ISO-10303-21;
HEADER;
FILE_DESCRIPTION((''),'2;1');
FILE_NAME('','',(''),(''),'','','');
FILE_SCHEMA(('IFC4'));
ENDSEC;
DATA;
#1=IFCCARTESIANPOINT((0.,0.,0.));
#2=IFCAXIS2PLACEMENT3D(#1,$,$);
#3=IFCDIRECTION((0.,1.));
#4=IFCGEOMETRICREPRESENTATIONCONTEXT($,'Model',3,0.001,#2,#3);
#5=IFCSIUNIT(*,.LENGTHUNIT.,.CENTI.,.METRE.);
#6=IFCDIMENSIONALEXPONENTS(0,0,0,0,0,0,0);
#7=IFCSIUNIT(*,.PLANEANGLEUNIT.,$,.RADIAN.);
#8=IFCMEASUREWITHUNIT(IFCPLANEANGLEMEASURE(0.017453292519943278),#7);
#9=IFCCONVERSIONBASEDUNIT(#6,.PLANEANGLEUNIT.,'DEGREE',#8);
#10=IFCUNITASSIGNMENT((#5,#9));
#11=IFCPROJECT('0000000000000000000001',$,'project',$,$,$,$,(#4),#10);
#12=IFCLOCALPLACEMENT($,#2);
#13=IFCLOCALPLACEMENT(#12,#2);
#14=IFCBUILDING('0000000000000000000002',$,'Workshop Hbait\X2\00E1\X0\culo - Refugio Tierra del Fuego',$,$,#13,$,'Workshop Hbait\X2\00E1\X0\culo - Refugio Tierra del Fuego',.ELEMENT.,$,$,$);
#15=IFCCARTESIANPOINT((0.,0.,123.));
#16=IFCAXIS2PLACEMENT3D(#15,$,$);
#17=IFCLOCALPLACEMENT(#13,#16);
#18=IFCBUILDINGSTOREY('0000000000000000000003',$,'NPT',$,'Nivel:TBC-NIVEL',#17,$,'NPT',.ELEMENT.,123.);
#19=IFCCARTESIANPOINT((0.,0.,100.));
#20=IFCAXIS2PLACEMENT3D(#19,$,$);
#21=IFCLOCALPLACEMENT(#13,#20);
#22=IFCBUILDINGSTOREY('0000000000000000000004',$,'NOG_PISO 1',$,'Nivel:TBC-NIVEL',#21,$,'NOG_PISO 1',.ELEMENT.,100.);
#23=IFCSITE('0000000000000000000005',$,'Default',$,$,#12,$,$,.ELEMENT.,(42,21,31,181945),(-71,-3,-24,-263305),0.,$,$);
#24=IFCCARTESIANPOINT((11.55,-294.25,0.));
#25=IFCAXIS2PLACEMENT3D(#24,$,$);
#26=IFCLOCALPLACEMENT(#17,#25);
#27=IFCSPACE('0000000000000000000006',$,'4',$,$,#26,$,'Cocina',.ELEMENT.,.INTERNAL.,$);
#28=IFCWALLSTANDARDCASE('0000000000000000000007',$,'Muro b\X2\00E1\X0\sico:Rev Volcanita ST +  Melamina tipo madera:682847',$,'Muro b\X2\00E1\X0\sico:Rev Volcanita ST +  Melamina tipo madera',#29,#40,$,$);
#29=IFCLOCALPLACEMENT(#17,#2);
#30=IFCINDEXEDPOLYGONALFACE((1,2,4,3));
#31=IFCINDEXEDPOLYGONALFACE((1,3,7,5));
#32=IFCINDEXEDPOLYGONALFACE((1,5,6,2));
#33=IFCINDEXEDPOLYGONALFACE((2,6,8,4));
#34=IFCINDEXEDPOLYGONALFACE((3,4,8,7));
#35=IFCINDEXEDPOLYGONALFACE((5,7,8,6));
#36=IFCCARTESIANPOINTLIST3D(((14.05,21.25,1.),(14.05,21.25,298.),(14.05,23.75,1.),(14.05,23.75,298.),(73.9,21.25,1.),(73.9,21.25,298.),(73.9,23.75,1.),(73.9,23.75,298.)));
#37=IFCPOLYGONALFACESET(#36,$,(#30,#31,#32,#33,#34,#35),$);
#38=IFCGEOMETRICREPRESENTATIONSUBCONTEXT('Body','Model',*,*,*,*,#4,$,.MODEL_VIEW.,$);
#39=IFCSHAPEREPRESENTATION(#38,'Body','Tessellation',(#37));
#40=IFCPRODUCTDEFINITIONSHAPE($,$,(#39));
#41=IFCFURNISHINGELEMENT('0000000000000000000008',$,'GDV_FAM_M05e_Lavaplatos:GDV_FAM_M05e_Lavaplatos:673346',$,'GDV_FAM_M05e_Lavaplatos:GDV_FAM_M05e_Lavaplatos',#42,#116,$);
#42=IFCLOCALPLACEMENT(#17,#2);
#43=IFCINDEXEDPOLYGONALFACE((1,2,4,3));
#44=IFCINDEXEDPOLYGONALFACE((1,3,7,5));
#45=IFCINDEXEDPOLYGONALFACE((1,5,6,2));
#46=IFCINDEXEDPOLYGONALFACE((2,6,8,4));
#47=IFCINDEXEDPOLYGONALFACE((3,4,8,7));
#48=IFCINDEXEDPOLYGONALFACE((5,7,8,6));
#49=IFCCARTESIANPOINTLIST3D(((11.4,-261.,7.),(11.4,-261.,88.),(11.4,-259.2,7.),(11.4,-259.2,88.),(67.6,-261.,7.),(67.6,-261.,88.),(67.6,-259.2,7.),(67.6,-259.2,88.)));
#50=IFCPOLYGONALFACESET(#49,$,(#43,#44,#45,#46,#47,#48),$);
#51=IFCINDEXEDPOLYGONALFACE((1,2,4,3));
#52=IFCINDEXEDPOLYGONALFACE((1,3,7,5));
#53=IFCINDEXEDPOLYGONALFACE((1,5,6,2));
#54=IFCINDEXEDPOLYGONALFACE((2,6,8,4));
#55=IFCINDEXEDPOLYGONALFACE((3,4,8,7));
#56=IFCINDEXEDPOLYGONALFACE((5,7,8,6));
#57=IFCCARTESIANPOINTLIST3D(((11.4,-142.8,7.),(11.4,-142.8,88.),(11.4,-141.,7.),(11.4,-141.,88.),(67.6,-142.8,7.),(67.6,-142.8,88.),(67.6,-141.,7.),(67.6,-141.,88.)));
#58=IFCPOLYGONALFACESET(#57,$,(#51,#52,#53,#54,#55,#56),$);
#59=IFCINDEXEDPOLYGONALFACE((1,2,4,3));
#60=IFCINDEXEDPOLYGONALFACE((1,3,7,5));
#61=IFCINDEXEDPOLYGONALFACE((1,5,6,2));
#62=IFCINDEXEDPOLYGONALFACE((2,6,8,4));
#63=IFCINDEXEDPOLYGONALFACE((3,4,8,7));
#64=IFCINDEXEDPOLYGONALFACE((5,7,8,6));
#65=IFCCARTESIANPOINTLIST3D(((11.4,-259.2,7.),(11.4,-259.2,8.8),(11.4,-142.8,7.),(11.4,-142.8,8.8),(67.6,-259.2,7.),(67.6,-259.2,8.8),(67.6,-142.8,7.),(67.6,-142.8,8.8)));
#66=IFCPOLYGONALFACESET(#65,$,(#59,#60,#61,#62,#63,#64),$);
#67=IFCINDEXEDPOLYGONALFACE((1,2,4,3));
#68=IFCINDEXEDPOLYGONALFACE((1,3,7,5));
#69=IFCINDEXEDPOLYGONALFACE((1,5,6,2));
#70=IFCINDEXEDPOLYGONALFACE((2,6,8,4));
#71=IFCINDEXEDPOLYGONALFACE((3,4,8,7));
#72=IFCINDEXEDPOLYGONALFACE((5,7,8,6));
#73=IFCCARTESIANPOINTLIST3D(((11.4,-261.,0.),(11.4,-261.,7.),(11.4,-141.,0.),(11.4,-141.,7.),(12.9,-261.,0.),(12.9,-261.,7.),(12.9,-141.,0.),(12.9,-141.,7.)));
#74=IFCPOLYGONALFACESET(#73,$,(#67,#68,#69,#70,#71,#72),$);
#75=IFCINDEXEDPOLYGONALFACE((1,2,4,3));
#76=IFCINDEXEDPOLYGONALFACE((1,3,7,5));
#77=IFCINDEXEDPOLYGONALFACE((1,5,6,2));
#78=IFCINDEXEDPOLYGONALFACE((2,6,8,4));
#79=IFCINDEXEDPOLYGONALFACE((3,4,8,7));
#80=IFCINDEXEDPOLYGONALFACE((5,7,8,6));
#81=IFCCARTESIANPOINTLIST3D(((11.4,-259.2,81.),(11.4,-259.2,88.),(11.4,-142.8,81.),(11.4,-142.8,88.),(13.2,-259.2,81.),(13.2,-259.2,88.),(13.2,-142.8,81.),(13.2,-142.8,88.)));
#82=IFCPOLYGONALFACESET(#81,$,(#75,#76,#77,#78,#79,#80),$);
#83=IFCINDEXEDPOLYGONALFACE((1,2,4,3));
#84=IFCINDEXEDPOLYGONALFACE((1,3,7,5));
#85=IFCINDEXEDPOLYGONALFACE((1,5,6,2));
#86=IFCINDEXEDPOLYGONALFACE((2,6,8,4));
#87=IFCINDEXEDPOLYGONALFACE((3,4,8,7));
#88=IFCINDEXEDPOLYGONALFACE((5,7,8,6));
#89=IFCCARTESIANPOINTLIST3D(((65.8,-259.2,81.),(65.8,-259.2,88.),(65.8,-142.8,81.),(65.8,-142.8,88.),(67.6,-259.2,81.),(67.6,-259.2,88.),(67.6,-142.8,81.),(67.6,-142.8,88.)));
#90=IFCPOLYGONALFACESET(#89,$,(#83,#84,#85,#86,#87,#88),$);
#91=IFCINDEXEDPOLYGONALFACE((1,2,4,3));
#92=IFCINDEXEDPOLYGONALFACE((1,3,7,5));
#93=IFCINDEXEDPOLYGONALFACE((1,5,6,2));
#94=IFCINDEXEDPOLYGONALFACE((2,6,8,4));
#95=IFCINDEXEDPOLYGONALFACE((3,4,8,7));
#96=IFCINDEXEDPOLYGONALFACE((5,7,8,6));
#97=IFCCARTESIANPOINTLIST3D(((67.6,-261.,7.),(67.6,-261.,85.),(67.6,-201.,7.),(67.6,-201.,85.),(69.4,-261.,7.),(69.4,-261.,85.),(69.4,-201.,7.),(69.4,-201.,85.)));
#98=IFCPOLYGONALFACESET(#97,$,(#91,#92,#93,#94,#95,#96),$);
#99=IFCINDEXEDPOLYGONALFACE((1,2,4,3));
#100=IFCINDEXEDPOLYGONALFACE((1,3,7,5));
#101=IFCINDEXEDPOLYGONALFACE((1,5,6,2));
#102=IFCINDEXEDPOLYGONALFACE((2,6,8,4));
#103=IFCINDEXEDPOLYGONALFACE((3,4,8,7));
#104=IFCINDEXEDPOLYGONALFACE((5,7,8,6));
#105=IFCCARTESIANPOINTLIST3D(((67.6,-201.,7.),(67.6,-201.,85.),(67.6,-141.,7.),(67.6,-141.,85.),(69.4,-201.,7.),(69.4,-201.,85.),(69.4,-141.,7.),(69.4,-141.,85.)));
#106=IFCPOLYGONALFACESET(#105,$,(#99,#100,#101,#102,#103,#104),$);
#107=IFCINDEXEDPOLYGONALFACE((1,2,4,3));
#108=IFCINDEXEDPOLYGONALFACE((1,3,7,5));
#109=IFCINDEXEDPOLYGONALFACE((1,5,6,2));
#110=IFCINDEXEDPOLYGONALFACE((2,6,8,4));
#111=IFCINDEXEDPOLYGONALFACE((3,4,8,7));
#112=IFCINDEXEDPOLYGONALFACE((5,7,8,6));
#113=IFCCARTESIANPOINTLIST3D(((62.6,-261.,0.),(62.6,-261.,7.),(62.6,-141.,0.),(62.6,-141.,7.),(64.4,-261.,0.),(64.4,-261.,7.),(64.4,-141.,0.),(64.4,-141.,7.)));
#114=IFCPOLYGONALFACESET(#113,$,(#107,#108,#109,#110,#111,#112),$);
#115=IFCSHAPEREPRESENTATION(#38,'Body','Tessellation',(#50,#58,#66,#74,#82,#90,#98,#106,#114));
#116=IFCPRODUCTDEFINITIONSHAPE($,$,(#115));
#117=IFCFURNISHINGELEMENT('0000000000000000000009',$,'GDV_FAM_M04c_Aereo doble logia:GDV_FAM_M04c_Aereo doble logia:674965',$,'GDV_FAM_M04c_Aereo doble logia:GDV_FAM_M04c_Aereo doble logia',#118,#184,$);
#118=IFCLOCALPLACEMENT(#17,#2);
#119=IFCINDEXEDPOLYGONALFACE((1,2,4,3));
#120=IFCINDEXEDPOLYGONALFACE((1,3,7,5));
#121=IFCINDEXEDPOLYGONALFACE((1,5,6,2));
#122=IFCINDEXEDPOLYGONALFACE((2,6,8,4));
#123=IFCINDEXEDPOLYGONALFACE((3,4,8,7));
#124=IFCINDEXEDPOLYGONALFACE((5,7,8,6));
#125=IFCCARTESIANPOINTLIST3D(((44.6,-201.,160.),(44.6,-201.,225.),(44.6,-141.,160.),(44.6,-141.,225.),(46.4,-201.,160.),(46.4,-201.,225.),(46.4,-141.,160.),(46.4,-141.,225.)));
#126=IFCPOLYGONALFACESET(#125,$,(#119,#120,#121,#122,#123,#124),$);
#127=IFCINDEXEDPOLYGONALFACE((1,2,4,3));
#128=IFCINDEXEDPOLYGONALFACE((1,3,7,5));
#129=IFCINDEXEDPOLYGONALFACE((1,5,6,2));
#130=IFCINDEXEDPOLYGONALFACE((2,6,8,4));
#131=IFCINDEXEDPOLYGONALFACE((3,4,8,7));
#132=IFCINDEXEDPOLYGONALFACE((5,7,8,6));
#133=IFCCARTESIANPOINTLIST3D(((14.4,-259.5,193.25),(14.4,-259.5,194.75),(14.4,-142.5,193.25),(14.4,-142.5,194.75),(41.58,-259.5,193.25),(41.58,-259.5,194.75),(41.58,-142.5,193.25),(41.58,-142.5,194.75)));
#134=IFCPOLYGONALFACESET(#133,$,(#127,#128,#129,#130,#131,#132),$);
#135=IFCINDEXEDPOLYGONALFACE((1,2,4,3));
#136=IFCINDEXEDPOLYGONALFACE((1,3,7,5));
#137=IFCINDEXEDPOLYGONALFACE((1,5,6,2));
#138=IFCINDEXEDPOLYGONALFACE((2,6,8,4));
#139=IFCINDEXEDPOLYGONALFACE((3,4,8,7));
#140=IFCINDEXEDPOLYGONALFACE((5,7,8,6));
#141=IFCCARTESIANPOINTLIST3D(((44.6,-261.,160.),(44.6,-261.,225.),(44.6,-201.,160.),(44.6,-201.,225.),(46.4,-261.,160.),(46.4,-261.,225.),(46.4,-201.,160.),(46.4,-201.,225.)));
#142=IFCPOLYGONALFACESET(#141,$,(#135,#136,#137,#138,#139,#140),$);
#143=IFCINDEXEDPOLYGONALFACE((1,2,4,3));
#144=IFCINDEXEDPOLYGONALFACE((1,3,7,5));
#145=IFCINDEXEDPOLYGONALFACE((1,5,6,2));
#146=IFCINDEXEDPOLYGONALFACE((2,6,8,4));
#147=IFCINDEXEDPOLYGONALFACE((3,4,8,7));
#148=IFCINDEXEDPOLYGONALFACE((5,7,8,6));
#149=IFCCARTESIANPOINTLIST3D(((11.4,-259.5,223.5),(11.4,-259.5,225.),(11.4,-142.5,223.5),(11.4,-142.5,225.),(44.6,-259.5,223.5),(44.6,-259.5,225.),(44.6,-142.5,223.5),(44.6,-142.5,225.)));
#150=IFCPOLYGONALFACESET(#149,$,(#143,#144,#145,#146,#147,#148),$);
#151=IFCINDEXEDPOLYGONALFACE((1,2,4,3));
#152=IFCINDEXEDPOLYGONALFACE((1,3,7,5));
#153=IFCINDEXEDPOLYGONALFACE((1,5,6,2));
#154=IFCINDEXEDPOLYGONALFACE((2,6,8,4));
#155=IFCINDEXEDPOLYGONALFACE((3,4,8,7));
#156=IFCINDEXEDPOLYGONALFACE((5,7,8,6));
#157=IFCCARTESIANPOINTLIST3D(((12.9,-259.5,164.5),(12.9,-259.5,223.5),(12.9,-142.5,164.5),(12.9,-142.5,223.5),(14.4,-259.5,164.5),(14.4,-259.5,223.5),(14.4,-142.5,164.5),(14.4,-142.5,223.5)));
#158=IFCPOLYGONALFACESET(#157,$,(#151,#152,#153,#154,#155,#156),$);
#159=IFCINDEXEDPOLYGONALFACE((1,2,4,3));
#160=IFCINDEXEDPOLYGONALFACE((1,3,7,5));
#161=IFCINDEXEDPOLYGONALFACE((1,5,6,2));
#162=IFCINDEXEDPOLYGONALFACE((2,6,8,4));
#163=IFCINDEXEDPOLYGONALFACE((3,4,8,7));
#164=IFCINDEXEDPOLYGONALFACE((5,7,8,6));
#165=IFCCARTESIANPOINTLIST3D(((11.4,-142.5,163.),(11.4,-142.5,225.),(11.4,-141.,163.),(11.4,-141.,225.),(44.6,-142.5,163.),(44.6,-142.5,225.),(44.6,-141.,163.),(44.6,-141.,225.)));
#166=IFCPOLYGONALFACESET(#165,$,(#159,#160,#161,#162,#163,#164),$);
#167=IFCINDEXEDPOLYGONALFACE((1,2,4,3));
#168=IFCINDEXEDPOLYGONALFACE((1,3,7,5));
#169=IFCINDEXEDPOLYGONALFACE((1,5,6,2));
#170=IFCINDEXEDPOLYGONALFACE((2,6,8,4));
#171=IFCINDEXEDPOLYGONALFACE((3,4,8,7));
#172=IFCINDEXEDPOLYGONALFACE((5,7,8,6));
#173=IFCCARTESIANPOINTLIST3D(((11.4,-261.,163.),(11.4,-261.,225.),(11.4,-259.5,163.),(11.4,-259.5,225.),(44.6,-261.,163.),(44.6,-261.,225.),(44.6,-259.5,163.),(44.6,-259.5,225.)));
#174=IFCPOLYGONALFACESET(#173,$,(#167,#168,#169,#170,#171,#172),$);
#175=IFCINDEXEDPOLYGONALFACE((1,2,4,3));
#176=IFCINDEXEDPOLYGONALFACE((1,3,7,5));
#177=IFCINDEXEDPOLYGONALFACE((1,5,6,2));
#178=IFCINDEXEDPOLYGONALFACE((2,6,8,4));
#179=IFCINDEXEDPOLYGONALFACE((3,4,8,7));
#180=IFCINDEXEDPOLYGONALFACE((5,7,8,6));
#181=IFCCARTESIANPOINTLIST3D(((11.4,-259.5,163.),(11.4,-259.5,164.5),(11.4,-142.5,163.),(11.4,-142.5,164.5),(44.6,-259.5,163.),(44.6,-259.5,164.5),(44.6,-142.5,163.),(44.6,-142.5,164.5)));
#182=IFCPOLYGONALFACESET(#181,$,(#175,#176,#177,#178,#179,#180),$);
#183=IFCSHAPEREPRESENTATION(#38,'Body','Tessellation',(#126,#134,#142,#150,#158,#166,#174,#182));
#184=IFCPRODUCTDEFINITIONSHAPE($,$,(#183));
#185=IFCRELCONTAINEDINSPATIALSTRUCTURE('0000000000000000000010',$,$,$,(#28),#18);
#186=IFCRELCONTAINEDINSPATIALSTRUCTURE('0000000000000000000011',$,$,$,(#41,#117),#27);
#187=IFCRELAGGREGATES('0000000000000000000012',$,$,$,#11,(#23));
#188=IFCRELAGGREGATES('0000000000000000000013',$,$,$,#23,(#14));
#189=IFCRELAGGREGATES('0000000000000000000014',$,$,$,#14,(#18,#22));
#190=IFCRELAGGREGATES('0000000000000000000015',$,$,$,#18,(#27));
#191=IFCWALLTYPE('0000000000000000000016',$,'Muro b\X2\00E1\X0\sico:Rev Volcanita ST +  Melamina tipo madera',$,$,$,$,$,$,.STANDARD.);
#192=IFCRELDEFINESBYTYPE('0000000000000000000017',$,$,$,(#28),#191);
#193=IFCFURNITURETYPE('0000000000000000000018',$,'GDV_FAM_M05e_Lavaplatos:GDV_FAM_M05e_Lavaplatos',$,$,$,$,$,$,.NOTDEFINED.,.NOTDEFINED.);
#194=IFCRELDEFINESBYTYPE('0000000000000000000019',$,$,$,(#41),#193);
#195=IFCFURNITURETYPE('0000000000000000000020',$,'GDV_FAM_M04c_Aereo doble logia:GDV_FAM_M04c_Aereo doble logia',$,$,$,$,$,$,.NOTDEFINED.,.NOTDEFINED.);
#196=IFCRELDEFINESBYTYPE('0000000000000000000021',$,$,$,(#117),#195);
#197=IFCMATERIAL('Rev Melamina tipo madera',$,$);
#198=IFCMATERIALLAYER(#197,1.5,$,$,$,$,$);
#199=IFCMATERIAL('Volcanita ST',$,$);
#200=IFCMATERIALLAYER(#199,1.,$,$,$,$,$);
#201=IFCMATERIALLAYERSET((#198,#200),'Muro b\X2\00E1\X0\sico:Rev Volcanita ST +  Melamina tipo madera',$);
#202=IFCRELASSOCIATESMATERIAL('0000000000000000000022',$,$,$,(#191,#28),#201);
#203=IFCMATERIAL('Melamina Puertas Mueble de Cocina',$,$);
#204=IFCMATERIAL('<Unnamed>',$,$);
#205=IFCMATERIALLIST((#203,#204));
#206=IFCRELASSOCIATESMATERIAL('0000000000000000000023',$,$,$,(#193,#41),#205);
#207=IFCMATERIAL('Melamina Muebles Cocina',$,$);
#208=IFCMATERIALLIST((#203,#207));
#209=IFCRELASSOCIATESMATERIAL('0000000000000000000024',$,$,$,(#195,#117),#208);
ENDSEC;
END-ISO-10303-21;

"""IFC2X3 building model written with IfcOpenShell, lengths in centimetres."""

from ifc_helpers import new_model, entity, si_unit, converted_unit, direction, frame, frame_2d, origin, origin_2d_with_axis, place, context, subcontext, project, spatial, rectangle, extrude, source, transform, mapped, material, material_list, layer, layer_set, layer_usage, type_object, type_shapes, element, save


model = new_model("IFC2X3")

# Units and contexts
model_context = context("Model", 3, precision=0.001, world=origin(), true_north=direction((0.0, 1.0)))
body_context = subcontext(model_context, "Body", "Model", "MODEL_VIEW")
ifc_project = project(units=[si_unit("LENGTHUNIT", "METRE", prefix="CENTI"), converted_unit("PLANEANGLEUNIT", "DEGREE", entity("IfcPlaneAngleMeasure", 0.017453292519943278), si_unit("PLANEANGLEUNIT", "RADIAN"), dimensions=[0, 0, 0, 0, 0, 0, 0])], contexts=[model_context])

# Site, building, storey
site_placement = place(None, origin())
site = spatial("IfcSite", under=ifc_project, at=site_placement, Name="Default", CompositionType="ELEMENT", RefLatitude=(42, 21, 31, 181945), RefLongitude=(-71, -3, -24, -263305), RefElevation=0.0)
building_placement = place(site_placement, origin())
building = spatial("IfcBuilding", under=site, at=building_placement, Name="Workshop Hbaitáculo - Refugio Tierra del Fuego", LongName="Workshop Hbaitáculo - Refugio Tierra del Fuego", CompositionType="ELEMENT")
storey_1_placement = place(building_placement, frame((0.0, 0.0, 123.0)))
storey_1 = spatial("IfcBuildingStorey", under=building, at=storey_1_placement, Name="NPT", ObjectType="Nivel:TBC-NIVEL", LongName="NPT", CompositionType="ELEMENT", Elevation=123.0)

# Shared definitions
storey_2_placement = place(building_placement, frame((0.0, 0.0, 100.0)))
storey_2 = spatial("IfcBuildingStorey", under=building, at=storey_2_placement, Name="NOG_PISO 1", ObjectType="Nivel:TBC-NIVEL", LongName="NOG_PISO 1", CompositionType="ELEMENT", Elevation=100.0)

# Shared definitions
ifc_material_1 = material(Name="Rev Melamina tipo madera")
ifc_layer_1 = layer(ifc_material_1, 1.5)
ifc_material_2 = material(Name="Volcanita ST")
ifc_layer_2 = layer(ifc_material_2, 1.0)
ifc_layer_set_1 = layer_set([ifc_layer_1, ifc_layer_2], Name="Muro básico:Rev Volcanita ST +  Melamina tipo madera")
wall_type_1 = type_object("IfcWallType", Name="Muro básico:Rev Volcanita ST +  Melamina tipo madera", PredefinedType="STANDARD", material=ifc_layer_set_1)

# Wall
ifc_layer_usage_1 = layer_usage(ifc_layer_set_1, "AXIS2", "NEGATIVE", 1.25)
wall_1_placement = place(storey_1_placement, frame((14.05, 22.5, 1.0)))
element("IfcWallStandardCase", 1, at=wall_1_placement, inside=storey_1, type_object=wall_type_1, material=ifc_layer_usage_1, Name="Muro básico:Rev Volcanita ST +  Melamina tipo madera:682847", ObjectType="Muro básico:Rev Volcanita ST +  Melamina tipo madera", context=body_context, shape_type="SweptSolid", body=[
    extrude(rectangle(XDim=59.85, YDim=2.5, at=frame_2d((29.93, 0.0), x_axis=(-1.0, 0.0))), origin(), (0.0, 0.0, 1.0), 297.0),
])

# Shared definitions
space_placement = place(storey_1_placement, frame((11.55, -294.25, 0.0)))
space = spatial("IfcSpace", under=storey_1, at=space_placement, Name="4", LongName="Cocina", CompositionType="ELEMENT", InteriorOrExteriorSpace="INTERNAL")

# Furnishing elements
ifc_material_3 = material(Name="Melamina Puertas Mueble de Cocina")
ifc_material_4 = material(Name="<Unnamed>")
ifc_material_list_1 = material_list([ifc_material_3, ifc_material_4])
furniture_type_1 = type_object("IfcFurnitureType", Name="GDV_FAM_M05e_Lavaplatos:GDV_FAM_M05e_Lavaplatos", AssemblyPlace="NOTDEFINED", material=ifc_material_list_1)
shared_shape_1 = source(origin(), body_context, "Body", "SweptSolid", [
    extrude(rectangle(XDim=1.8, YDim=56.2, at=frame_2d((0.0, 0.0), x_axis=(1.0, 0.0))), frame((39.5, -260.1, 130.0), z_axis=(0.0, 0.0, 1.0), x_axis=(0.0, -1.0, 0.0)), (0.0, 0.0, 1.0), 81.0),
    extrude(rectangle(XDim=1.8, YDim=56.2, at=origin_2d_with_axis()), frame((39.5, -141.9, 130.0), z_axis=(0.0, 0.0, 1.0), x_axis=(0.0, -1.0, 0.0)), (0.0, 0.0, 1.0), 81.0),
    extrude(rectangle(XDim=116.4, YDim=56.2, at=frame_2d((0.0, 0.0), x_axis=(1.0, 0.0))), frame((39.5, -201.0, 130.0), z_axis=(0.0, 0.0, 1.0), x_axis=(0.0, -1.0, 0.0)), (0.0, 0.0, 1.0), 1.8),
    extrude(rectangle(XDim=120.0, YDim=1.5, at=origin_2d_with_axis()), frame((12.15, -201.0, 123.0), z_axis=(0.0, 0.0, 1.0), x_axis=(0.0, -1.0, 0.0)), (0.0, 0.0, 1.0), 7.0),
    extrude(rectangle(XDim=116.4, YDim=1.8, at=frame_2d((0.0, 0.0), x_axis=(1.0, 0.0))), frame((12.3, -201.0, 204.0), z_axis=(0.0, 0.0, 1.0), x_axis=(0.0, -1.0, 0.0)), (0.0, 0.0, 1.0), 7.0),
    extrude(rectangle(XDim=116.4, YDim=1.8, at=frame_2d((0.0, 0.0), x_axis=(1.0, 0.0))), frame((66.7, -201.0, 204.0), z_axis=(0.0, 0.0, 1.0), x_axis=(0.0, -1.0, 0.0)), (0.0, 0.0, 1.0), 7.0),
    extrude(rectangle(XDim=60.0, YDim=1.8, at=frame_2d((0.0, 0.0), x_axis=(1.0, 0.0))), frame((68.5, -231.0, 130.0), z_axis=(0.0, 0.0, 1.0), x_axis=(0.0, -1.0, 0.0)), (0.0, 0.0, 1.0), 78.0),
    extrude(rectangle(XDim=60.0, YDim=1.8, at=frame_2d((0.0, 0.0), x_axis=(1.0, 0.0))), frame((68.5, -171.0, 130.0), z_axis=(0.0, 0.0, 1.0), x_axis=(0.0, -1.0, 0.0)), (0.0, 0.0, 1.0), 78.0),
    extrude(rectangle(XDim=120.0, YDim=1.8, at=origin_2d_with_axis()), frame((63.5, -201.0, 123.0), z_axis=(0.0, 0.0, 1.0), x_axis=(0.0, -1.0, 0.0)), (0.0, 0.0, 1.0), 7.0),
])
type_shapes(furniture_type_1, [shared_shape_1])
furnishing_1_placement = place(space_placement, frame((-11.55, 294.25, -123.0)))
element("IfcFurnishingElement", 2, at=furnishing_1_placement, inside=space, type_object=furniture_type_1, material=ifc_material_list_1, Name="GDV_FAM_M05e_Lavaplatos:GDV_FAM_M05e_Lavaplatos:673346", ObjectType="GDV_FAM_M05e_Lavaplatos:GDV_FAM_M05e_Lavaplatos", context=body_context, shape_type="MappedRepresentation", body=[
    mapped(shared_shape_1, transform((0.0, 0.0, 0.0), scale=1.0)),
])
ifc_material_5 = material(Name="Melamina Muebles Cocina")
ifc_material_list_2 = material_list([ifc_material_3, ifc_material_5])
furniture_type_2 = type_object("IfcFurnitureType", Name="GDV_FAM_M04c_Aereo doble logia:GDV_FAM_M04c_Aereo doble logia", AssemblyPlace="NOTDEFINED", material=ifc_material_list_2)
shared_shape_2 = source(origin(), body_context, "Body", "SweptSolid", [
    extrude(rectangle(XDim=60.0, YDim=1.8, at=frame_2d((0.0, 0.0), x_axis=(1.0, 0.0))), frame((90.0, -34.1, 0.0), z_axis=(0.0, 0.0, 1.0), x_axis=(-1.0, 0.0, 0.0)), (0.0, 0.0, 1.0), 65.0),
    extrude(rectangle(XDim=117.0, YDim=27.18, at=origin_2d_with_axis()), frame((60.0, -16.59, 33.25), z_axis=(0.0, 0.0, 1.0), x_axis=(-1.0, 0.0, 0.0)), (0.0, 0.0, 1.0), 1.5),
    extrude(rectangle(XDim=60.0, YDim=1.8, at=frame_2d((0.0, 0.0), x_axis=(1.0, 0.0))), frame((30.0, -34.1, 0.0), z_axis=(0.0, 0.0, 1.0), x_axis=(-1.0, 0.0, 0.0)), (0.0, 0.0, 1.0), 65.0),
    extrude(rectangle(XDim=117.0, YDim=33.2, at=origin_2d_with_axis()), frame((60.0, -16.6, 63.5), z_axis=(0.0, 0.0, 1.0), x_axis=(-1.0, 0.0, 0.0)), (0.0, 0.0, 1.0), 1.5),
    extrude(rectangle(XDim=117.0, YDim=1.5, at=origin_2d_with_axis()), frame((60.0, -2.25, 4.5), z_axis=(0.0, 0.0, 1.0), x_axis=(-1.0, 0.0, 0.0)), (0.0, 0.0, 1.0), 59.0),
    extrude(rectangle(XDim=33.2, YDim=1.5, at=origin_2d_with_axis()), frame((119.25, -16.6, 3.0), z_axis=(0.0, 0.0, 1.0), x_axis=(0.0, 1.0, 0.0)), (0.0, 0.0, 1.0), 62.0),
    extrude(rectangle(XDim=33.2, YDim=1.5, at=origin_2d_with_axis()), frame((0.75, -16.6, 3.0), z_axis=(0.0, 0.0, 1.0), x_axis=(0.0, 1.0, 0.0)), (0.0, 0.0, 1.0), 62.0),
    extrude(rectangle(XDim=117.0, YDim=33.2, at=origin_2d_with_axis()), frame((60.0, -16.6, 3.0), z_axis=(0.0, 0.0, 1.0), x_axis=(-1.0, 0.0, 0.0)), (0.0, 0.0, 1.0), 1.5),
])
type_shapes(furniture_type_2, [shared_shape_2])
furnishing_2_placement = place(space_placement, frame((-0.15, 33.25, 160.0), z_axis=(0.0, 0.0, 1.0), x_axis=(0.0, 1.0, 0.0)))
element("IfcFurnishingElement", 3, at=furnishing_2_placement, inside=space, type_object=furniture_type_2, material=ifc_material_list_2, Name="GDV_FAM_M04c_Aereo doble logia:GDV_FAM_M04c_Aereo doble logia:674965", ObjectType="GDV_FAM_M04c_Aereo doble logia:GDV_FAM_M04c_Aereo doble logia", context=body_context, shape_type="MappedRepresentation", body=[
    mapped(shared_shape_2, transform((0.0, 0.0, 0.0), scale=1.0)),
])

save(model, "model.ifc")
